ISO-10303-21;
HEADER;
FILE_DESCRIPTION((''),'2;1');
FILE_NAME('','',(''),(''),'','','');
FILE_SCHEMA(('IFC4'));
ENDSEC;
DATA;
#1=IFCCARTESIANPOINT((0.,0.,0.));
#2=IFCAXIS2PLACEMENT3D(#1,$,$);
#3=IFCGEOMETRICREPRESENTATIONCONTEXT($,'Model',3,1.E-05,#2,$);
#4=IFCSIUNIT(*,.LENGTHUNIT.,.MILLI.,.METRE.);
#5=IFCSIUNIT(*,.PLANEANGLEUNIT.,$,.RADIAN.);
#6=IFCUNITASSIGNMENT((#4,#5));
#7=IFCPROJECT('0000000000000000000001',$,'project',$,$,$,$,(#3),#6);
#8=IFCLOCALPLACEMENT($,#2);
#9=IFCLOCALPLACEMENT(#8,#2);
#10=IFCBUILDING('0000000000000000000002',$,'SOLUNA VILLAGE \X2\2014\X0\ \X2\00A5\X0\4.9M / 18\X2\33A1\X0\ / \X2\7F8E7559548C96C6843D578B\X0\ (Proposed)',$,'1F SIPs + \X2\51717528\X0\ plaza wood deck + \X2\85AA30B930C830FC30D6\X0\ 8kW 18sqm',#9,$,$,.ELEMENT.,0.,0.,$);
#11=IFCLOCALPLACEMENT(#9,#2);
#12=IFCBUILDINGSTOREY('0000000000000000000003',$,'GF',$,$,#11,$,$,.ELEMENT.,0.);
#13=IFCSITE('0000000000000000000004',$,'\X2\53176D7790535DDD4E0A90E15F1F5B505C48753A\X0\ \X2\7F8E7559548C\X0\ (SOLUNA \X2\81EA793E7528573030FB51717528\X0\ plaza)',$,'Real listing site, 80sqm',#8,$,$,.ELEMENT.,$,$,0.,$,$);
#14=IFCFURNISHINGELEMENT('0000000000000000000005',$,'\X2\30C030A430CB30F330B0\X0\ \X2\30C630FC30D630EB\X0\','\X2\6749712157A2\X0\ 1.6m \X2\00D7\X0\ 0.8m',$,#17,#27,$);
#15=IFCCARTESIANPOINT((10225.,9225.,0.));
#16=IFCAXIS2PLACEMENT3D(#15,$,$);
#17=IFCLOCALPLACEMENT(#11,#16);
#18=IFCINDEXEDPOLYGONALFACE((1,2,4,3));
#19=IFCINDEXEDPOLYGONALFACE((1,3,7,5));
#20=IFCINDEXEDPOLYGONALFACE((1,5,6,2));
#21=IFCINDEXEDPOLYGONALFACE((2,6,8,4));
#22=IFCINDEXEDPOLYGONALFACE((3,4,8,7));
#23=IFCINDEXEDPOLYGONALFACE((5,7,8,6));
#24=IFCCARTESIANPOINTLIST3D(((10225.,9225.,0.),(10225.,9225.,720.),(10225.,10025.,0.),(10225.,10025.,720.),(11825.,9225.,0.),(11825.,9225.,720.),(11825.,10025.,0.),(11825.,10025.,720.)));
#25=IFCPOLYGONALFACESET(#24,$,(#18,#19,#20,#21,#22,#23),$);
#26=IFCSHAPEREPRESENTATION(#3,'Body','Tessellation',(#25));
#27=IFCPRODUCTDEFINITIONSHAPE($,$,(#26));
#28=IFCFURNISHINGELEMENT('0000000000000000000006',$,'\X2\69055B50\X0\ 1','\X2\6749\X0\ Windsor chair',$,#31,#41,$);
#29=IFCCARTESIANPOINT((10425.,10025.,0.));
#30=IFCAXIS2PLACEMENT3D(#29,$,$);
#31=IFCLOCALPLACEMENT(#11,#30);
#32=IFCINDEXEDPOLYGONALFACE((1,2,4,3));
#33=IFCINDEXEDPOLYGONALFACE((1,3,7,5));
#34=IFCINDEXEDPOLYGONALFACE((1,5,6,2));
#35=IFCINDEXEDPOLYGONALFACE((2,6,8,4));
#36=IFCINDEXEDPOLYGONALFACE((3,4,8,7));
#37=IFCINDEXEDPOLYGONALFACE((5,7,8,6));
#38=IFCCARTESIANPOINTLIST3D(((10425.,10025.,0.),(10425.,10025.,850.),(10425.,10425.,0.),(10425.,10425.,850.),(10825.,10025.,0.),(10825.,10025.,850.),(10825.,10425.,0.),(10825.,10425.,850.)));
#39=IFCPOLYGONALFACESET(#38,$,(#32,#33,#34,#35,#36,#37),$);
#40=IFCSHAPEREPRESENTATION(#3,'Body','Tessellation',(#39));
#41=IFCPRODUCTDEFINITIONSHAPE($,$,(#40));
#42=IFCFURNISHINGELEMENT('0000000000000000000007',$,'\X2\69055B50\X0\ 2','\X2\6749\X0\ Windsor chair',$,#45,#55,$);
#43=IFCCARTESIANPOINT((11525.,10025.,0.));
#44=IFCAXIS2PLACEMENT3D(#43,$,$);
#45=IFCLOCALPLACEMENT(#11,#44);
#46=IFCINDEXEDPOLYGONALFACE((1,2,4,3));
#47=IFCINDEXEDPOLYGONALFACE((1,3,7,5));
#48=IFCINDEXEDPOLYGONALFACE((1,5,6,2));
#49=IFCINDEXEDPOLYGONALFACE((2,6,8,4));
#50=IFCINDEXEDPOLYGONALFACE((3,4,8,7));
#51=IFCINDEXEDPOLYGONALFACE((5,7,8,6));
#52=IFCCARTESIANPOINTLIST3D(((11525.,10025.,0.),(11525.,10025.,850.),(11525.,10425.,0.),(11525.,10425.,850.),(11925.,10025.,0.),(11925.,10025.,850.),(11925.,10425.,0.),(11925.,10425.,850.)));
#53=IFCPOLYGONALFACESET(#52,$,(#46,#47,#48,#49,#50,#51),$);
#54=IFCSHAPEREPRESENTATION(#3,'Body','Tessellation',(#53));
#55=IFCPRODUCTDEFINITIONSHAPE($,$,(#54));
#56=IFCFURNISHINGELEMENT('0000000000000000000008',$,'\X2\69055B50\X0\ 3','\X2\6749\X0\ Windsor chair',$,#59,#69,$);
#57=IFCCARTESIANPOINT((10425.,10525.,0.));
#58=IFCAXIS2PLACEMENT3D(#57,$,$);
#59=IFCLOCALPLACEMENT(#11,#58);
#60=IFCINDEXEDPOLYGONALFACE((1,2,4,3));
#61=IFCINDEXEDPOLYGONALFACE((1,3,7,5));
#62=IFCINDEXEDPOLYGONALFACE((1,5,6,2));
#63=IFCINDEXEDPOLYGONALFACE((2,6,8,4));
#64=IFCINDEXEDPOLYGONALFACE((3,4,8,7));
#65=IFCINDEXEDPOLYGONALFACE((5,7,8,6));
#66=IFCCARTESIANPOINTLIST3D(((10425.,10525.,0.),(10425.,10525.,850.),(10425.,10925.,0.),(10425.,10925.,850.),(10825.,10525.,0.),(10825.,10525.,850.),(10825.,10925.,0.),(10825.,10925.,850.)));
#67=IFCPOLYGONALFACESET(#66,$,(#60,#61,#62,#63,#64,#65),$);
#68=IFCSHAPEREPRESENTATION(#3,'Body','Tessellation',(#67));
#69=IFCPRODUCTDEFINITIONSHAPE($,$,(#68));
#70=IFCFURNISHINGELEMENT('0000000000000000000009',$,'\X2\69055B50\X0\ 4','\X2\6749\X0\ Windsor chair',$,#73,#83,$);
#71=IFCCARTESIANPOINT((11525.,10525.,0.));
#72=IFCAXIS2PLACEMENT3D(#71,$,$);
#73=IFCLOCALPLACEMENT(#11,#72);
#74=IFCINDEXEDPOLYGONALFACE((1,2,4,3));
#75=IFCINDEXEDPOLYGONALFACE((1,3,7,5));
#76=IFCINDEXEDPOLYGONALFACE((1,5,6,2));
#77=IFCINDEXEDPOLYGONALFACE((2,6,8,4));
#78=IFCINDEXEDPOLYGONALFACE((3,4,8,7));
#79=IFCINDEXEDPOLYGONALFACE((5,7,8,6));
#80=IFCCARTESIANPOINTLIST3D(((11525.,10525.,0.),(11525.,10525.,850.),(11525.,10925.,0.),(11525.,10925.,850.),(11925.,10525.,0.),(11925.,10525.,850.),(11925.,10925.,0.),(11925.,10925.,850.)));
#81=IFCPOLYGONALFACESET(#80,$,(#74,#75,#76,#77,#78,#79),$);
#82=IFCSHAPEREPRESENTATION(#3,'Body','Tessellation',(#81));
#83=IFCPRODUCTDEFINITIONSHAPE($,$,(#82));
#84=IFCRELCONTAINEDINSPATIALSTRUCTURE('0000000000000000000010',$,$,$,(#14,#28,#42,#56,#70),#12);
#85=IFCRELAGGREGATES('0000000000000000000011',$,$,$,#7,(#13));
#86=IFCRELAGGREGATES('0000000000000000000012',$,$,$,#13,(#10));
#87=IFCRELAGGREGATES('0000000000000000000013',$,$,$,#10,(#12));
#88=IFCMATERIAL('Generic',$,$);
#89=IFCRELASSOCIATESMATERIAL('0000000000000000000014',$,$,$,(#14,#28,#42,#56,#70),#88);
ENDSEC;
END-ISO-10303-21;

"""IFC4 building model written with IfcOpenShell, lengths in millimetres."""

from ifc_helpers import new_model, si_unit, frame, frame_2d, origin, place, context, project, spatial, rectangle, extrude, material, element, save


model = new_model("IFC4")

# Units and contexts
model_context = context("Model", 3, precision=1e-05, world=origin())
ifc_project = project(units=[si_unit("LENGTHUNIT", "METRE", prefix="MILLI"), si_unit("PLANEANGLEUNIT", "RADIAN")], contexts=[model_context])

# Site, building, storey
site_placement = place(None, origin())
site = spatial("IfcSite", under=ifc_project, at=site_placement, Name="北海道川上郡弟子屈町 美留和 (SOLUNA 自社用地・共用 plaza)", ObjectType="Real listing site, 80sqm", CompositionType="ELEMENT", RefElevation=0.0)
building_placement = place(site_placement, origin())
building = spatial("IfcBuilding", under=site, at=building_placement, Name="SOLUNA VILLAGE — ¥4.9M / 18㎡ / 美留和集落型 (Proposed)", ObjectType="1F SIPs + 共用 plaza wood deck + 薪ストーブ 8kW 18sqm", CompositionType="ELEMENT", ElevationOfRefHeight=0.0, ElevationOfTerrain=0.0)
storey_placement = place(building_placement, origin())
storey = spatial("IfcBuildingStorey", under=building, at=storey_placement, Name="GF", CompositionType="ELEMENT", Elevation=0.0)

# Shared definitions
ifc_material_1 = material(Name="Generic")

# Furnishing elements
furnishing_1_placement = place(storey_placement, frame((10225.0, 9225.0, 0.0)))
element("IfcFurnishingElement", 1, at=furnishing_1_placement, inside=storey, material=ifc_material_1, Name="ダイニング テーブル", Description="杉無垢 1.6m × 0.8m", context=model_context, shape_type="SweptSolid", body=[
    extrude(rectangle(XDim=1600.0, YDim=800.0, at=frame_2d((800.0, 400.0))), frame((10225.0, 9225.0, 0.0)), (0.0, 0.0, 1.0), 720.0),
])
furnishing_2_placement = place(storey_placement, frame((10425.0, 10025.0, 0.0)))
element("IfcFurnishingElement", 2, at=furnishing_2_placement, inside=storey, material=ifc_material_1, Name="椅子 1", Description="杉 Windsor chair", context=model_context, shape_type="SweptSolid", body=[
    extrude(rectangle(XDim=400.0, YDim=400.0, at=frame_2d((200.0, 200.0))), frame((10425.0, 10025.0, 0.0)), (0.0, 0.0, 1.0), 850.0),
])
furnishing_3_placement = place(storey_placement, frame((11525.0, 10025.0, 0.0)))
element("IfcFurnishingElement", 3, at=furnishing_3_placement, inside=storey, material=ifc_material_1, Name="椅子 2", Description="杉 Windsor chair", context=model_context, shape_type="SweptSolid", body=[
    extrude(rectangle(XDim=400.0, YDim=400.0, at=frame_2d((200.0, 200.0))), frame((11525.0, 10025.0, 0.0)), (0.0, 0.0, 1.0), 850.0),
])
furnishing_4_placement = place(storey_placement, frame((10425.0, 10525.0, 0.0)))
element("IfcFurnishingElement", 4, at=furnishing_4_placement, inside=storey, material=ifc_material_1, Name="椅子 3", Description="杉 Windsor chair", context=model_context, shape_type="SweptSolid", body=[
    extrude(rectangle(XDim=400.0, YDim=400.0, at=frame_2d((200.0, 200.0))), frame((10425.0, 10525.0, 0.0)), (0.0, 0.0, 1.0), 850.0),
])
furnishing_5_placement = place(storey_placement, frame((11525.0, 10525.0, 0.0)))
element("IfcFurnishingElement", 5, at=furnishing_5_placement, inside=storey, material=ifc_material_1, Name="椅子 4", Description="杉 Windsor chair", context=model_context, shape_type="SweptSolid", body=[
    extrude(rectangle(XDim=400.0, YDim=400.0, at=frame_2d((200.0, 200.0))), frame((11525.0, 10525.0, 0.0)), (0.0, 0.0, 1.0), 850.0),
])

save(model, "model.ifc")
